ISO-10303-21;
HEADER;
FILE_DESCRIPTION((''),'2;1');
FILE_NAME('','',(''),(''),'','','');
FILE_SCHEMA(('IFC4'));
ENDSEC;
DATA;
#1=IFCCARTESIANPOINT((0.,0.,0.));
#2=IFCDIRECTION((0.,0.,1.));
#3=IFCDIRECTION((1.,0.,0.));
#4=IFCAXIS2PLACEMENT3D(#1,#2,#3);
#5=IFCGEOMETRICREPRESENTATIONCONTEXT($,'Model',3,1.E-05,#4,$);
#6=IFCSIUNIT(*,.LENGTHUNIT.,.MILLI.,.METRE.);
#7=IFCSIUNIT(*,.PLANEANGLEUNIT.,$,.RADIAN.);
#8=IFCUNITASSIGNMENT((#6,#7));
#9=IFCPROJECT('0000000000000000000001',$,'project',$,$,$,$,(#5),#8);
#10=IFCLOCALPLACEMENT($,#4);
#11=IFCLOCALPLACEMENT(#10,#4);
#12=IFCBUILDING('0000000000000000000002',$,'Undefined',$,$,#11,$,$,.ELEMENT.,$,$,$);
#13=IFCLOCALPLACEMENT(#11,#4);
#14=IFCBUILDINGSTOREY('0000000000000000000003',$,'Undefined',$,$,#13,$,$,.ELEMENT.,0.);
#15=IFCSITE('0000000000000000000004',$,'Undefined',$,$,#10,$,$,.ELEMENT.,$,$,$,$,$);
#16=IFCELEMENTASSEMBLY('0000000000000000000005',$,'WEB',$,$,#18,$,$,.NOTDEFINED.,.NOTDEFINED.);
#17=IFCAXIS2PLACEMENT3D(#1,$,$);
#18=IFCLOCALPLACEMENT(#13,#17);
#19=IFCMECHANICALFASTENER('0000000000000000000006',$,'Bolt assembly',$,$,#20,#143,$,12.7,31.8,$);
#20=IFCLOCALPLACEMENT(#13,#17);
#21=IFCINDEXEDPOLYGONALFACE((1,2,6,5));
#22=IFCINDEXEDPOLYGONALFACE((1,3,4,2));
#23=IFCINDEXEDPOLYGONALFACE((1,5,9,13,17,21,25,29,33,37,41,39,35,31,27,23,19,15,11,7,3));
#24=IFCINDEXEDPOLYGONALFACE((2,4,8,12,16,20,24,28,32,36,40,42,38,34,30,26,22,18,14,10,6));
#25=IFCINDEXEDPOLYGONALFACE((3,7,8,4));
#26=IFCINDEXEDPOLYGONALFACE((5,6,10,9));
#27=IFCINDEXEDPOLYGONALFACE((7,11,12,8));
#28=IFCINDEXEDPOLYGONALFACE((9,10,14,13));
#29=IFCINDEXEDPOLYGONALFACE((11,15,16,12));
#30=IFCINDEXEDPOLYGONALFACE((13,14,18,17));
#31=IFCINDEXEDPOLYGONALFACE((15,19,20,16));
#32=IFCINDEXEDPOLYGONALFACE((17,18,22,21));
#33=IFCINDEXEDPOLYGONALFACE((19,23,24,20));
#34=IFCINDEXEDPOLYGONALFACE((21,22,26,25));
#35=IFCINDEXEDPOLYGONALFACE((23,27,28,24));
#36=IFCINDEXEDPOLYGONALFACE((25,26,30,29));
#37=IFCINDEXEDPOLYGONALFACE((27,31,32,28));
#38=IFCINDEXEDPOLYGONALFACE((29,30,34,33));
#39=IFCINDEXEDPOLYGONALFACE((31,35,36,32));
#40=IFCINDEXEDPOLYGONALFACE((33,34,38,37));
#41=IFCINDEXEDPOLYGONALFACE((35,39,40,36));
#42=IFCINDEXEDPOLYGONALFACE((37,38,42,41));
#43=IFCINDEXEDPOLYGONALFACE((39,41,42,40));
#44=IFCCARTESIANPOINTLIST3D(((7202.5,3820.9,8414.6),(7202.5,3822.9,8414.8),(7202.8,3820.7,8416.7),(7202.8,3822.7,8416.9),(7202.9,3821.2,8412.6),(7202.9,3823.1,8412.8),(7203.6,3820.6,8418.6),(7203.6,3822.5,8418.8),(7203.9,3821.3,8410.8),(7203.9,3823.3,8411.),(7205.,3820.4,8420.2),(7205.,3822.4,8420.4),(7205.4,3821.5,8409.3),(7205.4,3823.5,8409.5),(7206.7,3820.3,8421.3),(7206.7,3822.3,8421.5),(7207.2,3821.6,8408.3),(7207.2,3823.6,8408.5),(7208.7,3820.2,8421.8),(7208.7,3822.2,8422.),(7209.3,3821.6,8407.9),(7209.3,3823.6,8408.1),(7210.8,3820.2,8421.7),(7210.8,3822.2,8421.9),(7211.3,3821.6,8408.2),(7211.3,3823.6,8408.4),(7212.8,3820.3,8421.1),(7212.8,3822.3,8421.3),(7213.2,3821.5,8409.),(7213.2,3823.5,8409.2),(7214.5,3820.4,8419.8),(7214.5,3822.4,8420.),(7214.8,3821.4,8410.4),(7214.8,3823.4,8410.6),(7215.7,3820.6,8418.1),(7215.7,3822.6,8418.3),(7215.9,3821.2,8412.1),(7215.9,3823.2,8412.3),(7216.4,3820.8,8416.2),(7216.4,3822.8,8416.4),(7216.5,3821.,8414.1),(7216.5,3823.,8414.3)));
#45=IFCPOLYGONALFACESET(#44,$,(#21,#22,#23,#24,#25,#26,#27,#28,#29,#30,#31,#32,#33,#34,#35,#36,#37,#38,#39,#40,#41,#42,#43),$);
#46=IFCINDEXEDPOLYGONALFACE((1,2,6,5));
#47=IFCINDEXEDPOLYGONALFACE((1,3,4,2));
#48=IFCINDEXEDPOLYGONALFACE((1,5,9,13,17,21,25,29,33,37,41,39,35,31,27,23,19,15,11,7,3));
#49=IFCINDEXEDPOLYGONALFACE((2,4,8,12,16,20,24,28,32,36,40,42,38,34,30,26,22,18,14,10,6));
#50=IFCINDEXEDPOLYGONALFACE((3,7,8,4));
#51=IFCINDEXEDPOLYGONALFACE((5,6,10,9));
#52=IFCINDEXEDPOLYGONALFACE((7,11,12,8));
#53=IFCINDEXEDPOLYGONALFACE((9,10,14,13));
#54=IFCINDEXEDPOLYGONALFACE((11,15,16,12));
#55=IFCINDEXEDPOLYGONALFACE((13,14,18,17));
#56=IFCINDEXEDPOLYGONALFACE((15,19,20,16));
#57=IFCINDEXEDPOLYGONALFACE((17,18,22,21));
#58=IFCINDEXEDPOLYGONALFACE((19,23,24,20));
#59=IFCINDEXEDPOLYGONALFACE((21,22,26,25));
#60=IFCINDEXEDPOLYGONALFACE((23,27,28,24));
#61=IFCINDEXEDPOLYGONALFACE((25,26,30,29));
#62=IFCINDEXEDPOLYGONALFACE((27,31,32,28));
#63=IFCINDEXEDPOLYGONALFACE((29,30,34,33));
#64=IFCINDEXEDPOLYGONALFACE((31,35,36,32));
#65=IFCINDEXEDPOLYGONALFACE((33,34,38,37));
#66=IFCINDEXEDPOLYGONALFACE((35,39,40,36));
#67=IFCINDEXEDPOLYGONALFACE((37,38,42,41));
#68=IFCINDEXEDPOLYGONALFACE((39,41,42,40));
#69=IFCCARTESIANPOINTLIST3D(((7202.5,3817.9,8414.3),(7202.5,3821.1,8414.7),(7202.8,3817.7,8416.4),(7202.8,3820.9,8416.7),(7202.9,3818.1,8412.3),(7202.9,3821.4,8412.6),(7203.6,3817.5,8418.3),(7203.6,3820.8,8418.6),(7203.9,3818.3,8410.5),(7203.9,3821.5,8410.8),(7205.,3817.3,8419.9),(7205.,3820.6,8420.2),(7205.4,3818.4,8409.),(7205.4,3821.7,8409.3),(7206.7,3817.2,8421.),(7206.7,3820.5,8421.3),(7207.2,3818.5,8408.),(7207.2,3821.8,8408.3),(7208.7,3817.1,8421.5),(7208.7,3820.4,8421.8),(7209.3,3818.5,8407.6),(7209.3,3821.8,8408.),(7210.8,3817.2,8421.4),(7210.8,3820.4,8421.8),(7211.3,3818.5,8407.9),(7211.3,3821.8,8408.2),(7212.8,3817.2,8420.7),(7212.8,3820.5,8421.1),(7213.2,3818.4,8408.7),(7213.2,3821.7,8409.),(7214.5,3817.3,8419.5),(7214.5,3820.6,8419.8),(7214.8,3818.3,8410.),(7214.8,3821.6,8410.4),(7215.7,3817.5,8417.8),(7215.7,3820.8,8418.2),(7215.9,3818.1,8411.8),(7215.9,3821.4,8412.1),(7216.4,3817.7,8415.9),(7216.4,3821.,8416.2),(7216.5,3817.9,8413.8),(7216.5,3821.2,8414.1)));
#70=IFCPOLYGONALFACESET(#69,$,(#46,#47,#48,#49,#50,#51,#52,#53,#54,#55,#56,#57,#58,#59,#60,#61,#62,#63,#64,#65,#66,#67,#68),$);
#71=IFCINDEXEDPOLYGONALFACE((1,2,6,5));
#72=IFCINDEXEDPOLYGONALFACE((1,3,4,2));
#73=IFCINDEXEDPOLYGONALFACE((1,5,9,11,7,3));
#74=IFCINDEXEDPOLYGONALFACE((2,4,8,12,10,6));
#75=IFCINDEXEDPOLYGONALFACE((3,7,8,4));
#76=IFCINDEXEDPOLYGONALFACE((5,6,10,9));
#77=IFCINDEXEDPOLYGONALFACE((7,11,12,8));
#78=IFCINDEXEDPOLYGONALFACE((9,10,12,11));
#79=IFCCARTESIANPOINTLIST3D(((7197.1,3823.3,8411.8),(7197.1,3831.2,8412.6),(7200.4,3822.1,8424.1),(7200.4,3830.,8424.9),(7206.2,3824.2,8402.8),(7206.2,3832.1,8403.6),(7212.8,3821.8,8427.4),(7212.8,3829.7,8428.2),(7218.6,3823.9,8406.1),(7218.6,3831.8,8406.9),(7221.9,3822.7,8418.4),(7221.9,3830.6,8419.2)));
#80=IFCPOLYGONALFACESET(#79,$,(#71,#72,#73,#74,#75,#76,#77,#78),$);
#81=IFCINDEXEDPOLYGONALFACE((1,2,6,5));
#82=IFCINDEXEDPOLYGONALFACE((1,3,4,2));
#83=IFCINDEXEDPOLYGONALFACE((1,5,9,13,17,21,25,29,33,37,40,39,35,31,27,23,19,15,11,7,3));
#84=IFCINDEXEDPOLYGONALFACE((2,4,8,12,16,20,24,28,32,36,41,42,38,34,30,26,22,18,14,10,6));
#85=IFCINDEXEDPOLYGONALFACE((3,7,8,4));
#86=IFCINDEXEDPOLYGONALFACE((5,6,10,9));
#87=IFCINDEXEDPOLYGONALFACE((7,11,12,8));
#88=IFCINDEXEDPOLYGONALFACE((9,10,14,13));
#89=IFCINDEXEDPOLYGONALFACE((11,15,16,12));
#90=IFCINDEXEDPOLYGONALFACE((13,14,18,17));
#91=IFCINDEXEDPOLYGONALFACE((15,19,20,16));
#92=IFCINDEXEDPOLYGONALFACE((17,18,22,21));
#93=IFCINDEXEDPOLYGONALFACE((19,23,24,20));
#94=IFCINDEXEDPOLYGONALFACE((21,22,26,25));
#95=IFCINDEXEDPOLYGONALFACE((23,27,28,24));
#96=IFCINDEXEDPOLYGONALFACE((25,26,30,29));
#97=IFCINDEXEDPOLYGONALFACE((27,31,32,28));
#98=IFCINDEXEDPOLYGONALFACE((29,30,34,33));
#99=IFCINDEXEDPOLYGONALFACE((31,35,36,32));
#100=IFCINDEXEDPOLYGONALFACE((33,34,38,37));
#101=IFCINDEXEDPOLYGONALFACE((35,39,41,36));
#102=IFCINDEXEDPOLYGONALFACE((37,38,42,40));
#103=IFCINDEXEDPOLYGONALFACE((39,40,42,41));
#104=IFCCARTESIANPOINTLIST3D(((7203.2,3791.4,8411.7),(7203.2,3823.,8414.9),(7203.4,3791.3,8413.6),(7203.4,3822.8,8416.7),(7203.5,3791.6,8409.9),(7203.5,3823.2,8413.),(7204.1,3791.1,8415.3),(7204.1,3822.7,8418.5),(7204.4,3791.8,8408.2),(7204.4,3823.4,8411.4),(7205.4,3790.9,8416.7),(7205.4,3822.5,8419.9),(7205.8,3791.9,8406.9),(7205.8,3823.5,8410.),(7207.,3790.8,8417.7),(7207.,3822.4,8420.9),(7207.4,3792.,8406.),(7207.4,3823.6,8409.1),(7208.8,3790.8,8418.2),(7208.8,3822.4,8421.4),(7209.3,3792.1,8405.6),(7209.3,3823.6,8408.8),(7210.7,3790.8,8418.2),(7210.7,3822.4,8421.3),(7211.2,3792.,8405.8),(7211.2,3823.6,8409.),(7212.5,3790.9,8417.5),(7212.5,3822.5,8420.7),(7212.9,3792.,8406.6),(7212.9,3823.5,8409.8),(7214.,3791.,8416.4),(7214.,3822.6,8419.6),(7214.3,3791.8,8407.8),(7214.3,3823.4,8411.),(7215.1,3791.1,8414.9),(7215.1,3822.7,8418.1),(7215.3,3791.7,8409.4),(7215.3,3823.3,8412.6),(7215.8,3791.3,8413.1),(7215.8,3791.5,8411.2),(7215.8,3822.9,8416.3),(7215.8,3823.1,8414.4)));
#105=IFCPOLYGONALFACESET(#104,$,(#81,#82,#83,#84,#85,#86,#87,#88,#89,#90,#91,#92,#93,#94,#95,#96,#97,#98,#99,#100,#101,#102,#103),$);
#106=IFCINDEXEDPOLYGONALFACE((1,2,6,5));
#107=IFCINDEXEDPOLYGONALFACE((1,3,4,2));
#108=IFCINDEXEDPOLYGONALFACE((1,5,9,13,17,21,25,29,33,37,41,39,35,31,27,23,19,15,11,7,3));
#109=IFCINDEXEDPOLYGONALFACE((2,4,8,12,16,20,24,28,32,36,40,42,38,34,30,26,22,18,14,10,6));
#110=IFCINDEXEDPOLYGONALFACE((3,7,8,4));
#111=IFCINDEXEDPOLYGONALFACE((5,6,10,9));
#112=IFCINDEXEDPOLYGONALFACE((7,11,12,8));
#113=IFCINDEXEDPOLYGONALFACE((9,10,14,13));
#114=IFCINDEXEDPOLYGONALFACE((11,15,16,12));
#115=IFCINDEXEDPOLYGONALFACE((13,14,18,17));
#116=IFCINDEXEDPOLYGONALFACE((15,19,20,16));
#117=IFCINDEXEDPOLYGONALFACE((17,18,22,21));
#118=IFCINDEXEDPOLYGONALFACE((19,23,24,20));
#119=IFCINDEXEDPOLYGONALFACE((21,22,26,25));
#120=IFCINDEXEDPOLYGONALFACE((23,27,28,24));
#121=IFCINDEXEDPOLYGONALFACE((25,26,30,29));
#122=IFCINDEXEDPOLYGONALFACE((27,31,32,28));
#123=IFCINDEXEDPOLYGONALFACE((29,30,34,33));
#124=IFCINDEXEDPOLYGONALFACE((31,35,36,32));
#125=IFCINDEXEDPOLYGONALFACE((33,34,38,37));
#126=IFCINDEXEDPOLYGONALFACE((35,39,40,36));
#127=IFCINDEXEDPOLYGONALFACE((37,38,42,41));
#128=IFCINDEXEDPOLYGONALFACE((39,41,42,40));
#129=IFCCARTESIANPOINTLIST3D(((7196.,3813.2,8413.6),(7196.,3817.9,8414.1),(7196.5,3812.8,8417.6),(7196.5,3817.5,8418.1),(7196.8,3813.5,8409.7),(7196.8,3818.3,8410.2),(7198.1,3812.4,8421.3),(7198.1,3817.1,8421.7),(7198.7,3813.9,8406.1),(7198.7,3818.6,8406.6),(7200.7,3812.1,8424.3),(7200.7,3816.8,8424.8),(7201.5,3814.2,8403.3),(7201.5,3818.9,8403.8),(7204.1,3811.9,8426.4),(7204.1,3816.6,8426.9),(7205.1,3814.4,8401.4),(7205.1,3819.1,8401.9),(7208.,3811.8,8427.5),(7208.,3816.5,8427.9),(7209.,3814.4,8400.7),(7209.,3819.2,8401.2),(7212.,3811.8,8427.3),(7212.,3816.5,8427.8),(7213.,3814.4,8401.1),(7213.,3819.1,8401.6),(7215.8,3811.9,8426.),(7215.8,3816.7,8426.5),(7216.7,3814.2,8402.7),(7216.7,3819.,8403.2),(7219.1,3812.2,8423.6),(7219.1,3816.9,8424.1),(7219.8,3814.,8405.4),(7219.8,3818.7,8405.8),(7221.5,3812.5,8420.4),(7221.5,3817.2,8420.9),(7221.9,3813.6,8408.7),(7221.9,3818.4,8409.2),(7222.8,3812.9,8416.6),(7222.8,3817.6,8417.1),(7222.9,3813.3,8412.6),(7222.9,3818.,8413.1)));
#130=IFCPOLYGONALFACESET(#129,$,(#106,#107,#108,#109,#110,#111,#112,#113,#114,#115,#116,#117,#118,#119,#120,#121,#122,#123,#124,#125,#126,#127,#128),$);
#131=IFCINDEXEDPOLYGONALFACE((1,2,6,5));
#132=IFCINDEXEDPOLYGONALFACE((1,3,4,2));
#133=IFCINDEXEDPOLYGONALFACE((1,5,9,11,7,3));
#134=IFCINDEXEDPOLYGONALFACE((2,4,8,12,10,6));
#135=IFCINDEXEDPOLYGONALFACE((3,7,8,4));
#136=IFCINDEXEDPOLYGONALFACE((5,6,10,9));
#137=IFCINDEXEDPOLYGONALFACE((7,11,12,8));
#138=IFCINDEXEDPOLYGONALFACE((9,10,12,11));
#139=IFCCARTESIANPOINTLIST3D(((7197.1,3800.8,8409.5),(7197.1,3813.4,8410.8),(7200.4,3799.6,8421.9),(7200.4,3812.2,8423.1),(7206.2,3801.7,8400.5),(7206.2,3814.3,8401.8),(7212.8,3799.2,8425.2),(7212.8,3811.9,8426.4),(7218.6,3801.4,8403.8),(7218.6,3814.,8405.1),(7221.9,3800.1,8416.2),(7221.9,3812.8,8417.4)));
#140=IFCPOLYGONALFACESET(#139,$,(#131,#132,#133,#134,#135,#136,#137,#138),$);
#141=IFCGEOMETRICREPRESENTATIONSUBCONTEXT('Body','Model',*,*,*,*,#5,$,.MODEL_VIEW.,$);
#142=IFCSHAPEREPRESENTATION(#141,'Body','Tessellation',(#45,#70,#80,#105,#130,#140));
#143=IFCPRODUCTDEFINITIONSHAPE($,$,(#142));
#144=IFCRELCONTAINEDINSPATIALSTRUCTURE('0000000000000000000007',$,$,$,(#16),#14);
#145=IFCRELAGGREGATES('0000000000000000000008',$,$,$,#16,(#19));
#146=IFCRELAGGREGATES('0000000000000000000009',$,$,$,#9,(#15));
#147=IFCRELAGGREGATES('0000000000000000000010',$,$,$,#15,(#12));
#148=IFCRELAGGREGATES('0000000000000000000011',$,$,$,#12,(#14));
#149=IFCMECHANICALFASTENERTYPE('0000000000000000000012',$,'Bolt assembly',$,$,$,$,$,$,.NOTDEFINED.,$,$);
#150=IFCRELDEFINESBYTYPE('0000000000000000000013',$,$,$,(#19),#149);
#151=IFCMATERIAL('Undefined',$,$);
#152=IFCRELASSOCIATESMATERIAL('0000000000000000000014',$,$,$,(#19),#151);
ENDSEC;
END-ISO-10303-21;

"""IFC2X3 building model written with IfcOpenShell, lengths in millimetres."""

from ifc_helpers import new_model, si_unit, frame, origin_with_axes, origin_2d_with_axis, place, context, subcontext, project, spatial, polyline, circle, outline, extrude, source, transform, mapped, material, type_object, element, aggregate, save


model = new_model("IFC2X3")

# Units and contexts
model_context = context("Model", 3, precision=1e-05, world=origin_with_axes())
body_context = subcontext(model_context, "Body", "Model", "MODEL_VIEW")
ifc_project = project(units=[si_unit("LENGTHUNIT", "METRE", prefix="MILLI"), si_unit("PLANEANGLEUNIT", "RADIAN")], contexts=[model_context])

# Site, building, storey
site_placement = place(None, origin_with_axes())
site = spatial("IfcSite", under=ifc_project, at=site_placement, Name="Undefined", CompositionType="ELEMENT")
building_placement = place(site_placement, origin_with_axes())
building = spatial("IfcBuilding", under=site, at=building_placement, Name="Undefined", CompositionType="ELEMENT")
storey_placement = place(building_placement, origin_with_axes())
storey = spatial("IfcBuildingStorey", under=building, at=storey_placement, Name="Undefined", CompositionType="ELEMENT", Elevation=0.0)

# Element assembly, mechanical fastener
assembly_1_placement = place(storey_placement, origin_with_axes())
assembly_1 = element("IfcElementAssembly", 1, at=assembly_1_placement, inside=storey, Name="WEB", AssemblyPlace="NOTDEFINED", PredefinedType="NOTDEFINED")
ifc_material_1 = material(Name="Undefined")
mechanical_fastener_type = type_object("IfcMechanicalFastenerType", Name="Bolt assembly")
shared_shape_1 = source(origin_with_axes(), body_context, "Body", "SweptSolid", [
    extrude(circle(Radius=7.0, at=origin_2d_with_axis()), frame((0.0, -1.9, 0.0), z_axis=(0.0, 1.0, 0.0), x_axis=(1.0, 0.0, 0.0)), (0.0, 0.0, 1.0), 2.0),
    extrude(circle(Radius=7.0, at=origin_2d_with_axis()), frame((0.0, -0.1, 0.0), z_axis=(0.0, 1.0, 0.0), x_axis=(1.0, 0.0, 0.0)), (0.0, 0.0, 1.0), 3.3),
    extrude(outline(polyline([(11.1, -6.4), (11.1, 6.4), (0.0, 12.8), (-11.1, 6.4), (-11.1, -6.4), (0.0, -12.8), (11.1, -6.4)])), frame((0.0, -9.9, 0.0), z_axis=(0.0, 1.0, 0.0), x_axis=(1.0, 0.0, 0.0)), (0.0, 0.0, 1.0), 7.9),
    extrude(circle(Radius=6.3, at=origin_2d_with_axis()), frame((0.0, -2.0, 0.0), z_axis=(0.0, 1.0, 0.0), x_axis=(1.0, 0.0, 0.0)), (0.0, 0.0, 1.0), 31.8),
    extrude(circle(Radius=13.5, at=origin_2d_with_axis()), frame((0.0, 3.2, 0.0), z_axis=(0.0, 1.0, 0.0), x_axis=(1.0, 0.0, 0.0)), (0.0, 0.0, 1.0), 4.8),
    extrude(outline(polyline([(11.1, -6.4), (11.1, 6.4), (0.0, 12.8), (-11.1, 6.4), (-11.1, -6.4), (0.0, -12.8), (11.1, -6.4)])), frame((0.0, 8.0, 0.0), z_axis=(0.0, 1.0, 0.0), x_axis=(1.0, 0.0, 0.0)), (0.0, 0.0, 1.0), 12.7),
])
mechanical_fastener_1_placement = place(assembly_1_placement, frame((7209.5, 3821.0, 8414.9), z_axis=(0.707107, 0.07036, -0.703598), x_axis=(0.707107, -0.07036, 0.703598)))
mechanical_fastener_1 = element("IfcMechanicalFastener", 2, at=mechanical_fastener_1_placement, type_object=mechanical_fastener_type, material=ifc_material_1, Name="Bolt assembly", NominalDiameter=12.7, NominalLength=31.8, context=body_context, shape_type="MappedRepresentation", body=[
    mapped(shared_shape_1, transform((0.0, 0.0, 0.0))),
])
aggregate(assembly_1, [mechanical_fastener_1])

save(model, "model.ifc")
